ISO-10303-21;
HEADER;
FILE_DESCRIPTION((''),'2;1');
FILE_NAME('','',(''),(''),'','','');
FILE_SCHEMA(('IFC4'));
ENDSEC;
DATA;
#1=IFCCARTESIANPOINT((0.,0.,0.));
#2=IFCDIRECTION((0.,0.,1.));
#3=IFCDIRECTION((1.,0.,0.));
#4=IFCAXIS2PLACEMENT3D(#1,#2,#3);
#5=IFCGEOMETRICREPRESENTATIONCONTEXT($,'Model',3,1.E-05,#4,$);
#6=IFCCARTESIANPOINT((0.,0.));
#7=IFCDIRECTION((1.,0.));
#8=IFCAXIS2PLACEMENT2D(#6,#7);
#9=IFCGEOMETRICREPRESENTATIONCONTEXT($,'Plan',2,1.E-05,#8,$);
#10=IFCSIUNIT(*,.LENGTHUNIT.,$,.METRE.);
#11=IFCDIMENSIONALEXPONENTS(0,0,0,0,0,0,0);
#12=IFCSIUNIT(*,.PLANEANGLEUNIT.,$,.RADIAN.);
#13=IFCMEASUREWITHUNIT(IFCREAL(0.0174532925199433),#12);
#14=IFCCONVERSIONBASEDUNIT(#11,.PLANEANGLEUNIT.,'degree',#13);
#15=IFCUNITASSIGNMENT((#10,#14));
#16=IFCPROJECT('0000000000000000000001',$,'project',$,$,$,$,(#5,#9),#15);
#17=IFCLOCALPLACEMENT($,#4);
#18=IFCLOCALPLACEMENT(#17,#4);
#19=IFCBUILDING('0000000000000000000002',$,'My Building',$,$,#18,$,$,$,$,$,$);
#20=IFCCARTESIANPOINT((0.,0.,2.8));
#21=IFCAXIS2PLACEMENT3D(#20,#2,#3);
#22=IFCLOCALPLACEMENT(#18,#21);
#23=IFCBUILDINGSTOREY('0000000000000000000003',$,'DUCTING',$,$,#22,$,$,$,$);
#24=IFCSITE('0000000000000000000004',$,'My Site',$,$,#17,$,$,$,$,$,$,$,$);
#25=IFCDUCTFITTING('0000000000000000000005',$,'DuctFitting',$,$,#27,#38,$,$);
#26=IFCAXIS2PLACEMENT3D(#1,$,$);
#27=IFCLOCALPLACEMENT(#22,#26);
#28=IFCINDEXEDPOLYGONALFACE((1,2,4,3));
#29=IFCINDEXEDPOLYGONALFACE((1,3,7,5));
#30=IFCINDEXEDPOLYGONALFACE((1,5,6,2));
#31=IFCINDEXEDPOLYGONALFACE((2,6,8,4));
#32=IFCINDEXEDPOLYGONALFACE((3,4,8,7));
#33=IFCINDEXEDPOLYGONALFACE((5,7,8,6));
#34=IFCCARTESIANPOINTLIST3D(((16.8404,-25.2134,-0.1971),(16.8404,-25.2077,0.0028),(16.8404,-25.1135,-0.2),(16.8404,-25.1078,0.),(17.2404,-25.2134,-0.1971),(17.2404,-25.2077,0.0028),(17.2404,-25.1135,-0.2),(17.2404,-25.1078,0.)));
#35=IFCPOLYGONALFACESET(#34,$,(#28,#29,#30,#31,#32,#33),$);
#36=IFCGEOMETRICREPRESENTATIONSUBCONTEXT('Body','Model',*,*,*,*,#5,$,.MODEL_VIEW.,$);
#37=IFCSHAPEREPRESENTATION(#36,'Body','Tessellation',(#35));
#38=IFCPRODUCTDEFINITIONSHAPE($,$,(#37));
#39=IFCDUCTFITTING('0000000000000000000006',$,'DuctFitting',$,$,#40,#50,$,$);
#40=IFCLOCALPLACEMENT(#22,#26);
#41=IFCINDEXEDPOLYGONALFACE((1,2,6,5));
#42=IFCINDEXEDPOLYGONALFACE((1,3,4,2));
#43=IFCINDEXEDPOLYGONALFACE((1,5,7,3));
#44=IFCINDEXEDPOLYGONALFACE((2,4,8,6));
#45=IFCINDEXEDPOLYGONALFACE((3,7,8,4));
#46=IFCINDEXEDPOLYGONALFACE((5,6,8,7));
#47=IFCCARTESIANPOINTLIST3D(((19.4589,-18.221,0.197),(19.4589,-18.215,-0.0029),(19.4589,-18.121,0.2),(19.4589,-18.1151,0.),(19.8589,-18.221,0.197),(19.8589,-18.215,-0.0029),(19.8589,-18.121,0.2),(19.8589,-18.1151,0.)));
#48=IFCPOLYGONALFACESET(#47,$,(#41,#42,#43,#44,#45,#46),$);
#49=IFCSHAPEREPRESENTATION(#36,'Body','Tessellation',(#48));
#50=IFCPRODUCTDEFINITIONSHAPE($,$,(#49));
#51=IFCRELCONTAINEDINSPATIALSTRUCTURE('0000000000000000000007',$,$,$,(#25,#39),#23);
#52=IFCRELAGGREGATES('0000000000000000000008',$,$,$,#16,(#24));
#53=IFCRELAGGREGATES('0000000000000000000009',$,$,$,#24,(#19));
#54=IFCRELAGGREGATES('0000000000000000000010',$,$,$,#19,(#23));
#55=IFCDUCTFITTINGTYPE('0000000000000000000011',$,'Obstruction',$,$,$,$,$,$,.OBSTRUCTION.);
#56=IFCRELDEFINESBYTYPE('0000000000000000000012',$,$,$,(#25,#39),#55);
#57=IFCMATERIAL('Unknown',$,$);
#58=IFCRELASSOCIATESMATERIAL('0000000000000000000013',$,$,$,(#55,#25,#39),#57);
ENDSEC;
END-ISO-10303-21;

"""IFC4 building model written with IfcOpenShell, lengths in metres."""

from ifc_helpers import new_model, entity, si_unit, converted_unit, frame, origin_with_axes, origin_2d_with_axis, place, context, subcontext, project, spatial, rectangle, extrude, material, material_profile, profile_set, profile_usage, type_object, element, save


model = new_model("IFC4")

# Units and contexts
model_context = context("Model", 3, precision=1e-05, world=origin_with_axes())
plan_context = context("Plan", 2, precision=1e-05, world=origin_2d_with_axis())
body_context = subcontext(model_context, "Body", "Model", "MODEL_VIEW")
ifc_project = project(units=[si_unit("LENGTHUNIT", "METRE"), converted_unit("PLANEANGLEUNIT", "degree", entity("IfcReal", 0.0174532925199433), si_unit("PLANEANGLEUNIT", "RADIAN"), dimensions=[0, 0, 0, 0, 0, 0, 0])], contexts=[model_context, plan_context])

# Site, building, storey
site_placement = place(None, origin_with_axes())
site = spatial("IfcSite", under=ifc_project, at=site_placement, Name="My Site")
building_placement = place(site_placement, origin_with_axes())
building = spatial("IfcBuilding", under=site, at=building_placement, Name="My Building")
storey_placement = place(building_placement, frame((0.0, 0.0, 2.8), z_axis=(0.0, 0.0, 1.0), x_axis=(1.0, 0.0, 0.0)))
storey = spatial("IfcBuildingStorey", under=building, at=storey_placement, Name="DUCTING")

# Shared definitions
ifc_material = material(Name="Unknown")

# Duct fittings
ifc_material_profile_1 = material_profile(ifc_material, rectangle(XDim=0.4, YDim=0.2))
ifc_profile_set_1 = profile_set([ifc_material_profile_1])
duct_fitting_type_1 = type_object("IfcDuctFittingType", Name="Obstruction", PredefinedType="OBSTRUCTION", material=ifc_profile_set_1)
ifc_profile_usage_1 = profile_usage(ifc_profile_set_1, cardinal=5)
duct_fitting_1_placement = place(storey_placement, frame((17.0404, -25.1106, -0.1), z_axis=(0.0, -0.999595, 0.028448), x_axis=(1.0, 0.0, 0.0)))
element("IfcDuctFitting", 1, at=duct_fitting_1_placement, inside=storey, type_object=duct_fitting_type_1, material=ifc_profile_usage_1, Name="DuctFitting", context=body_context, shape_type="SweptSolid", body=[
    extrude(rectangle(XDim=0.4, YDim=0.2), origin_with_axes(), (0.0, 0.0, 1.0), 0.1),
])
ifc_profile_usage_2 = profile_usage(ifc_profile_set_1, cardinal=5)
duct_fitting_2_placement = place(storey_placement, frame((19.6589, -18.118, 0.1), z_axis=(-0.000001, -0.999553, -0.029908), x_axis=(1.0, -0.000001, 0.0)))
element("IfcDuctFitting", 2, at=duct_fitting_2_placement, inside=storey, type_object=duct_fitting_type_1, material=ifc_profile_usage_2, Name="DuctFitting", context=body_context, shape_type="SweptSolid", body=[
    extrude(rectangle(XDim=0.4, YDim=0.2), origin_with_axes(), (0.0, 0.0, 1.0), 0.1),
])

save(model, "model.ifc")
